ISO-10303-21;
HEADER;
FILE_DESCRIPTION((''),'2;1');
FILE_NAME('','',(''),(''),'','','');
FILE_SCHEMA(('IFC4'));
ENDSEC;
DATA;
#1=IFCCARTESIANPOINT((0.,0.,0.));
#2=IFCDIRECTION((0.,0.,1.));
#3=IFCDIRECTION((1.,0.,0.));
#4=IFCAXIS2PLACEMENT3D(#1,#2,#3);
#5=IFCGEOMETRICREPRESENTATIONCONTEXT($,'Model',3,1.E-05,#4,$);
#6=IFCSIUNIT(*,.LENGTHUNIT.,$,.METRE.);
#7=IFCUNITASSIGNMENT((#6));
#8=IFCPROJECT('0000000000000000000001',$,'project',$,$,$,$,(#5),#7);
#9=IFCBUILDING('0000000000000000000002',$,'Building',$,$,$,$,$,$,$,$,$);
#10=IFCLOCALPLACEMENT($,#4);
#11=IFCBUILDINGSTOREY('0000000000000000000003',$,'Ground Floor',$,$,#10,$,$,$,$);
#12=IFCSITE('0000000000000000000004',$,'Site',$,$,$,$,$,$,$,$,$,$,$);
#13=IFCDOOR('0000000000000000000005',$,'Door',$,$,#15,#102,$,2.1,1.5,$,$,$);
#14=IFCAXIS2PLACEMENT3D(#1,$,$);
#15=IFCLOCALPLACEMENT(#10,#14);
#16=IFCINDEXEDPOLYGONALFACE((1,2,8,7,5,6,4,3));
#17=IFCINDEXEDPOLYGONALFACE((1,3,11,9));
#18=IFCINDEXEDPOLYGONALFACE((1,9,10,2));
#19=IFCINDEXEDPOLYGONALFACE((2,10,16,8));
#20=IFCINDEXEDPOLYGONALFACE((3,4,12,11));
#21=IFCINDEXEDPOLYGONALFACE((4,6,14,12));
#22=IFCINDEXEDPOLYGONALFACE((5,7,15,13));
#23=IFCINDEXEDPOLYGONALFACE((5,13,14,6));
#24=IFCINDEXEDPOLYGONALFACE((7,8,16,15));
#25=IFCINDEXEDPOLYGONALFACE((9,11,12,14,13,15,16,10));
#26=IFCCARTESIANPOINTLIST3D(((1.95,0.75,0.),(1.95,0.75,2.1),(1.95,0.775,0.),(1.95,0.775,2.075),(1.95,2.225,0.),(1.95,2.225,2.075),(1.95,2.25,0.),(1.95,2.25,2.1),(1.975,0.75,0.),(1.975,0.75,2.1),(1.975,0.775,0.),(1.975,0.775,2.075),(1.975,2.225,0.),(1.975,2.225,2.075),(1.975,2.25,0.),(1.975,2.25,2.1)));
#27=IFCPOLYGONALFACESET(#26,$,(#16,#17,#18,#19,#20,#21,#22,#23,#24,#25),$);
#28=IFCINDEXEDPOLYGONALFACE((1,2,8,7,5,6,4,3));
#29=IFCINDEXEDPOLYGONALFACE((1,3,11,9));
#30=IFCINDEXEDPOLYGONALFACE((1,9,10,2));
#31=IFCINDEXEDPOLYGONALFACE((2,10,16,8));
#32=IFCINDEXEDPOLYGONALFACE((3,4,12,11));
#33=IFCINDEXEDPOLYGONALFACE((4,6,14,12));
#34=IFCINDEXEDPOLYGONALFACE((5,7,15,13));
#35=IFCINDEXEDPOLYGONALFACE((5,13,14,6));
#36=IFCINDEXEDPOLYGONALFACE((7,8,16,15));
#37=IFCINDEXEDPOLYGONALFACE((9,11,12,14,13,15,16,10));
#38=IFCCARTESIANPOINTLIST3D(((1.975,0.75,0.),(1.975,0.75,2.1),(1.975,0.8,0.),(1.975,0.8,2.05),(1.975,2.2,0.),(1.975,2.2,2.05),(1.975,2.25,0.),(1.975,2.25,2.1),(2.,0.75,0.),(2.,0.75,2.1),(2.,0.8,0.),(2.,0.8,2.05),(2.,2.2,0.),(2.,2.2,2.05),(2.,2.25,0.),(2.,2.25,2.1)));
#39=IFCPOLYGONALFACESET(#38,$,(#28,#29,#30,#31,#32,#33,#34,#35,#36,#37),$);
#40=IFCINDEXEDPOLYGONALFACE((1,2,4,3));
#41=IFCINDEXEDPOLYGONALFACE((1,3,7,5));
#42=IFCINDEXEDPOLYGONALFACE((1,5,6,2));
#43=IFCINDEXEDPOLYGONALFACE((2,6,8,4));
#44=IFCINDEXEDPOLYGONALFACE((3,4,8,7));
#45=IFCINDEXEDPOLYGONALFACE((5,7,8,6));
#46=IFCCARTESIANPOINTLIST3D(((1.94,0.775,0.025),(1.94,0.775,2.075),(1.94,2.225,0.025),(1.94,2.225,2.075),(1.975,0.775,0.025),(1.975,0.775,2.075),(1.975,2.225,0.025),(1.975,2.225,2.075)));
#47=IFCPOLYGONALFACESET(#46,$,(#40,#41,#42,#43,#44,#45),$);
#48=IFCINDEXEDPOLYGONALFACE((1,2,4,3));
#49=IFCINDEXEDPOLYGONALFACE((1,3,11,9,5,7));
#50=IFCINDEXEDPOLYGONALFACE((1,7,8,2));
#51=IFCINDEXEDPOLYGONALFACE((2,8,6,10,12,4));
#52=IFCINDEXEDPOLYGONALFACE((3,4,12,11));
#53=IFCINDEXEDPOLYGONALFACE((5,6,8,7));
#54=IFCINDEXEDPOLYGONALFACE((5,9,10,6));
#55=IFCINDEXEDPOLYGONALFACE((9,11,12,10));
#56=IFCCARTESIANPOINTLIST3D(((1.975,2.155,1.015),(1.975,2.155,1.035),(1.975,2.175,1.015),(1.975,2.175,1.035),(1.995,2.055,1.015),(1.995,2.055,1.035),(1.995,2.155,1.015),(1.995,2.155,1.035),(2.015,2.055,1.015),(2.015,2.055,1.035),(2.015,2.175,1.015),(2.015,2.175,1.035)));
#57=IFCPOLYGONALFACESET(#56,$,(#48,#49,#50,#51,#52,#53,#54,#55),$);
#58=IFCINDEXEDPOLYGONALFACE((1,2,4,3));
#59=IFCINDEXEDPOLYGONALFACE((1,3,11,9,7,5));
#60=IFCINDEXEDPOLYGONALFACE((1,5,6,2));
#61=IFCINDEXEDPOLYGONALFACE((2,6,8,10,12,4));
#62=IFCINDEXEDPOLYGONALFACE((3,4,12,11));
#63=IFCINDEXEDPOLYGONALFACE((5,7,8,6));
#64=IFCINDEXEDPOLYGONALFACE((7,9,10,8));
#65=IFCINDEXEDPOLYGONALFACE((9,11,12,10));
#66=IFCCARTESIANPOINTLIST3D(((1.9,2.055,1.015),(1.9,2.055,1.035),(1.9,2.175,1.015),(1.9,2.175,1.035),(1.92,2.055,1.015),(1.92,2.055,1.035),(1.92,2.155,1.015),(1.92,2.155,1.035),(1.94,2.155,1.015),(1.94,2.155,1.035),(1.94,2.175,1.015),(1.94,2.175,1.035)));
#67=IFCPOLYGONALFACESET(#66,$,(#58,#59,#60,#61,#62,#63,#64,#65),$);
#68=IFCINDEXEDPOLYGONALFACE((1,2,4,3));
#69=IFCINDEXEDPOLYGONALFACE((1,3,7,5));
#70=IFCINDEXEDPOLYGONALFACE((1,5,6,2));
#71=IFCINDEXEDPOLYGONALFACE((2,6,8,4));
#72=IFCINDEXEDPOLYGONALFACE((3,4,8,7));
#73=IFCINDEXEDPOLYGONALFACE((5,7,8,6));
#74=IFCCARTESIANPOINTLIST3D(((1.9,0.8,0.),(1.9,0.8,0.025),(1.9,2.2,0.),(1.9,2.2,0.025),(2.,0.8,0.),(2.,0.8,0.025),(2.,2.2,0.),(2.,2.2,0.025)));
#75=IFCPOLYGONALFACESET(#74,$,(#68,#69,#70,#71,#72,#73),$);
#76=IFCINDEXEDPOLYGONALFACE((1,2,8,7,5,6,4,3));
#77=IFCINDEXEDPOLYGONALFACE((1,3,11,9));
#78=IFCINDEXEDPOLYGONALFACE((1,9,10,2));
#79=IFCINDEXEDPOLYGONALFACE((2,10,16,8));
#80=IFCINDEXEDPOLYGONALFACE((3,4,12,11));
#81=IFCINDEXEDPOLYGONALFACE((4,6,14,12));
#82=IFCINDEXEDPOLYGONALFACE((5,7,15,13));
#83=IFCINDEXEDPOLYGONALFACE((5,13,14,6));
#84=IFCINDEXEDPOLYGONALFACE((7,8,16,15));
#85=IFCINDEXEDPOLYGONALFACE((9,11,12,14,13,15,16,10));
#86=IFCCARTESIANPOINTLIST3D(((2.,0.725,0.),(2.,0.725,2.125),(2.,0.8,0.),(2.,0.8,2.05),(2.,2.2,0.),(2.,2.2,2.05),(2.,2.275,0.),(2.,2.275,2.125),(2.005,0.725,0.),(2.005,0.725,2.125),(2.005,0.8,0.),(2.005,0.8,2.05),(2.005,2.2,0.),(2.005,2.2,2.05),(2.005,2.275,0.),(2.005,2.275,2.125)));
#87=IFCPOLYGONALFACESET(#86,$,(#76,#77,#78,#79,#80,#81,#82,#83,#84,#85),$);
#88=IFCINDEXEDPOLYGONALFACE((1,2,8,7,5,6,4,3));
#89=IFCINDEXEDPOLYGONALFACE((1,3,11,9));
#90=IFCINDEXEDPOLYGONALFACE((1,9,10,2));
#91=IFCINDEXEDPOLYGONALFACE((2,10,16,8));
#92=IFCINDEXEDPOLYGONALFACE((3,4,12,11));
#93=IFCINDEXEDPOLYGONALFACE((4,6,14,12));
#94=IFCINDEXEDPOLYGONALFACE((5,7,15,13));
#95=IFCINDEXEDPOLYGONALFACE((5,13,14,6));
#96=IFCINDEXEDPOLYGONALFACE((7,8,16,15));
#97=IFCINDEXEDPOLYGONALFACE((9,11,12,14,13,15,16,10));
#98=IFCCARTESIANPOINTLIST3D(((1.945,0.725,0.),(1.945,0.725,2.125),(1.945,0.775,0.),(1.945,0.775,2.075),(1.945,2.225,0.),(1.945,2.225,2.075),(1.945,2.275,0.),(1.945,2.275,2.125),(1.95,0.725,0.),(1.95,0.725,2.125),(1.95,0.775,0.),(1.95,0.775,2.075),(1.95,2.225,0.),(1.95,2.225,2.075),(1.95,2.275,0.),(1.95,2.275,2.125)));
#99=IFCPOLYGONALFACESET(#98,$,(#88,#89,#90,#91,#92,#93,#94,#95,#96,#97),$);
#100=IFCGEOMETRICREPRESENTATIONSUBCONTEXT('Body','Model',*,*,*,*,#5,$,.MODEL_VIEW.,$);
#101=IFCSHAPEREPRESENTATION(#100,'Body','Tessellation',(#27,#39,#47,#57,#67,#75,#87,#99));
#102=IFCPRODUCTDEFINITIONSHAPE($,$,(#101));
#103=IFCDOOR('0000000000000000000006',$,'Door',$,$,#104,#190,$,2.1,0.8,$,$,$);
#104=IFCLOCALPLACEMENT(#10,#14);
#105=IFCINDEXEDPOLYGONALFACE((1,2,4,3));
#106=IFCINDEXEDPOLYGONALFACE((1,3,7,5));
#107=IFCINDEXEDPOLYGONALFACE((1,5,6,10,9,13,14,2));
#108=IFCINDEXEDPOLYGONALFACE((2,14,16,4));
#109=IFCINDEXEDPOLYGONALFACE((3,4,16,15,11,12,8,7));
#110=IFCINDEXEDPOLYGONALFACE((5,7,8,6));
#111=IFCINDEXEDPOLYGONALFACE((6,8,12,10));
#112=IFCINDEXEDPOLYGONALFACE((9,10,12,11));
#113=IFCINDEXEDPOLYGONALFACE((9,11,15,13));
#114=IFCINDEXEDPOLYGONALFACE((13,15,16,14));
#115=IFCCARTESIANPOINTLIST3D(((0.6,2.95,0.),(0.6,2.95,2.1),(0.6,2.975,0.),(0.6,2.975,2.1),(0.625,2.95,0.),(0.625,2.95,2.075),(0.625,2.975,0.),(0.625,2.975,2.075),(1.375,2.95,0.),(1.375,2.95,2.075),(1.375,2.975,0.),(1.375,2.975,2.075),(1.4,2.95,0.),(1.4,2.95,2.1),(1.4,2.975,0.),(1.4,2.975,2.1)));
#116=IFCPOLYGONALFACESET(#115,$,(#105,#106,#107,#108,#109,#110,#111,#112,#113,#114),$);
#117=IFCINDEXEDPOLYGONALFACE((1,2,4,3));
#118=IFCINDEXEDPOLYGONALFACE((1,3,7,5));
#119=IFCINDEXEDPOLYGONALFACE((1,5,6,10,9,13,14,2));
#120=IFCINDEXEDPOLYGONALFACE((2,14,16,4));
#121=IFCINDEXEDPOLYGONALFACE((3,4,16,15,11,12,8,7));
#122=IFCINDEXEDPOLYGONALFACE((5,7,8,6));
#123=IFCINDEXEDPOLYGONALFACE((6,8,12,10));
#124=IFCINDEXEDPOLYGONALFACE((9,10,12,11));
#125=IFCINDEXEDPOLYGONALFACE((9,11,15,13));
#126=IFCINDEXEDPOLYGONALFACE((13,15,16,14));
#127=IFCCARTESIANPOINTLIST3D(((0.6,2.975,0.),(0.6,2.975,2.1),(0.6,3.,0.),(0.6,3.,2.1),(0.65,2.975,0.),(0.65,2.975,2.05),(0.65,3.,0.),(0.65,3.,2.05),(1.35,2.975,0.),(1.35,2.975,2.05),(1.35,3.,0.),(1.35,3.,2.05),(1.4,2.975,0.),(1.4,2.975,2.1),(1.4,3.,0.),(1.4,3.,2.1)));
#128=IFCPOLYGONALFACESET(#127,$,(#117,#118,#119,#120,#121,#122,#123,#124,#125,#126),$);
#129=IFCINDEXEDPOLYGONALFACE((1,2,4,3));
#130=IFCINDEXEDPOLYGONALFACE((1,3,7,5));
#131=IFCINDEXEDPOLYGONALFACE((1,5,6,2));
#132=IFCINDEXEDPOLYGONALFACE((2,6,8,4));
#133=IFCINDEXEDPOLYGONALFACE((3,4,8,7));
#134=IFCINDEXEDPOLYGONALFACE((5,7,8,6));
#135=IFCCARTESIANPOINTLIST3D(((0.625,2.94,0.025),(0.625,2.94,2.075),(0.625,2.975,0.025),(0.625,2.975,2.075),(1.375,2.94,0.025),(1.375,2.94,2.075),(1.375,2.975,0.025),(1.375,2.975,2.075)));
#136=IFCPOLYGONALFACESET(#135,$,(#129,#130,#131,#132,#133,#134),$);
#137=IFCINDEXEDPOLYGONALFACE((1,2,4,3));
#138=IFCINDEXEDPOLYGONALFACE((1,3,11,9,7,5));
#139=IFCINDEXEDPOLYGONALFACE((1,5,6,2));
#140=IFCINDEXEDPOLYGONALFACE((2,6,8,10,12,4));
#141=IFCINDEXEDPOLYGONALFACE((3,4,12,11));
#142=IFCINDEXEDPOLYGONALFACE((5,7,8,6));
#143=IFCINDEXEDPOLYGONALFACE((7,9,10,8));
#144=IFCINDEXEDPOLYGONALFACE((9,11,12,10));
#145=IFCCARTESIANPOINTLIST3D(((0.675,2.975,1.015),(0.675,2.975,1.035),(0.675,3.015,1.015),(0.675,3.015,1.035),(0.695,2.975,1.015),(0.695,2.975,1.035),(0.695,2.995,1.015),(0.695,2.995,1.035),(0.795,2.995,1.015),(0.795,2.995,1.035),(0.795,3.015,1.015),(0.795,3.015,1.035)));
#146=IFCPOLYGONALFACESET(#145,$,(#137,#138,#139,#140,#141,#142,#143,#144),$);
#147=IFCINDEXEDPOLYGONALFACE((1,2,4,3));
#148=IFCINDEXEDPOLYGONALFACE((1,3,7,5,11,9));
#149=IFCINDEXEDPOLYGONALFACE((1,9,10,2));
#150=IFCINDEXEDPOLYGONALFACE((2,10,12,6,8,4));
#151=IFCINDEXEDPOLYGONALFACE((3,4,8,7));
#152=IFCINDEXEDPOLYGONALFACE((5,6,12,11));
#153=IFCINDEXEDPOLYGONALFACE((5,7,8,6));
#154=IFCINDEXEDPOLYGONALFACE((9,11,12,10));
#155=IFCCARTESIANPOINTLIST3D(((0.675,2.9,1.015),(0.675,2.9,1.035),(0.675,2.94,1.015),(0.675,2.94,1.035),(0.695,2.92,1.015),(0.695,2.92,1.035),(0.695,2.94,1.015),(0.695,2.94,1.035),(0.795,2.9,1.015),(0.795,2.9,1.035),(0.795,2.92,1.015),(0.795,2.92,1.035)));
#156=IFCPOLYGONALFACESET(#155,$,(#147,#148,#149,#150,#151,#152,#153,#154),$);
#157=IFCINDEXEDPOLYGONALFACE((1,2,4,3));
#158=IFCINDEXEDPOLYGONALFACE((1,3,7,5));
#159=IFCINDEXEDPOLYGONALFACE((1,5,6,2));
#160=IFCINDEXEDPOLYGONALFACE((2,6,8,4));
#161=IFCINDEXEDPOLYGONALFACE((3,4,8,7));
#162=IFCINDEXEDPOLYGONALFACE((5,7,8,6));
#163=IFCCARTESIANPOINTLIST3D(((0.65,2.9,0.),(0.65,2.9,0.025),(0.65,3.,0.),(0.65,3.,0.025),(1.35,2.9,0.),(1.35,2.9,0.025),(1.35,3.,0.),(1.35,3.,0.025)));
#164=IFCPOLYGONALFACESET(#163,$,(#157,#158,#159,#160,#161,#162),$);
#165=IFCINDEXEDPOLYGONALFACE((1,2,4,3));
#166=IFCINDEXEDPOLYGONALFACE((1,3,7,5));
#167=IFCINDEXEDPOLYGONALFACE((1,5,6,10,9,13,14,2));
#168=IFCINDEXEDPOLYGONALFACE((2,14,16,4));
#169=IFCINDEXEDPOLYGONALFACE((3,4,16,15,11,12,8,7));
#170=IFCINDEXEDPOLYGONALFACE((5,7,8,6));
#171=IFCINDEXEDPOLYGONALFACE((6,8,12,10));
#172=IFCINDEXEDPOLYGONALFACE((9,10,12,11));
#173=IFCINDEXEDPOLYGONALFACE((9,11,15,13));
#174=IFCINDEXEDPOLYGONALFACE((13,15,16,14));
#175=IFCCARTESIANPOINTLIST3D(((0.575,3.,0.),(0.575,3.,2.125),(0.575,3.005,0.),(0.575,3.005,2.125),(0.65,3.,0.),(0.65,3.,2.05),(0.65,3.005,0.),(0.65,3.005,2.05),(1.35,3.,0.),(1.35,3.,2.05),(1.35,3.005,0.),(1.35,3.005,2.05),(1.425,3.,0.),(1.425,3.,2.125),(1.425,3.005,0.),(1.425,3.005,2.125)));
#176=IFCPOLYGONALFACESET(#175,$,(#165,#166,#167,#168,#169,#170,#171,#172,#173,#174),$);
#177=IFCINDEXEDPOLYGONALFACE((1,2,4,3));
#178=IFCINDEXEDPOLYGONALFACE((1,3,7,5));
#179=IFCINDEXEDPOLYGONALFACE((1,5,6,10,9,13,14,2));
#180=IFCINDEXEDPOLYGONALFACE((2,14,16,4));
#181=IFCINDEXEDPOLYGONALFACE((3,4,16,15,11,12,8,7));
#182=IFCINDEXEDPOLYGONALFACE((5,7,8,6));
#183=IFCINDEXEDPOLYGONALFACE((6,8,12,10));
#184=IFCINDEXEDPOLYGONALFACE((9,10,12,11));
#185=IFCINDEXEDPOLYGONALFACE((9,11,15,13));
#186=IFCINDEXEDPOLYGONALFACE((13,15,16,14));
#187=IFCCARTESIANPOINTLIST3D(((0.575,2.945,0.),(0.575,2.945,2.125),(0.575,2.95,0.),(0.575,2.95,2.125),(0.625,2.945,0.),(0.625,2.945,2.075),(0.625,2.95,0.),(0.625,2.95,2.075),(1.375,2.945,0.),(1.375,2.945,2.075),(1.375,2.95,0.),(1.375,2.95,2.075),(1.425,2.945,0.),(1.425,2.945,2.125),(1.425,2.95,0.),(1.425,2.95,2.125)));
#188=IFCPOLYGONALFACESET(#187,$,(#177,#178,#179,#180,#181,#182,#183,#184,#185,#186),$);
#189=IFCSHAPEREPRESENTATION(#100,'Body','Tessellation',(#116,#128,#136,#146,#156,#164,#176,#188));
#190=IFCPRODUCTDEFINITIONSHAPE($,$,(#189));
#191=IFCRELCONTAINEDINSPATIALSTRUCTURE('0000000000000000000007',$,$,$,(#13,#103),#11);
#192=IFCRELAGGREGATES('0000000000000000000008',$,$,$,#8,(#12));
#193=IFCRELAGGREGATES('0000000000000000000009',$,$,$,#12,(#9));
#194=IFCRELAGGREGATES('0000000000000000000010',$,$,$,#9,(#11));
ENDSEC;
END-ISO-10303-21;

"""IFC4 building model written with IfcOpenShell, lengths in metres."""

from ifc_helpers import new_model, si_unit, frame, origin_with_axes, place, context, subcontext, project, spatial, line, indexed_curve, outline, extrude, element, save


model = new_model("IFC4")

# Units and contexts
model_context = context("Model", 3, precision=1e-05, world=origin_with_axes())
body_context = subcontext(model_context, "Body", "Model", "MODEL_VIEW")
ifc_project = project(units=[si_unit("LENGTHUNIT", "METRE")], contexts=[model_context])

# Site, building, storey
site = spatial("IfcSite", under=ifc_project, Name="Site")
building = spatial("IfcBuilding", under=site, Name="Building")
storey_placement = place(None, origin_with_axes())
storey = spatial("IfcBuildingStorey", under=building, at=storey_placement, Name="Ground Floor")

# Doors
door_1_placement = place(storey_placement, frame((2.0, 0.75, 0.0), z_axis=(0.0, 0.0, 1.0), x_axis=(0.0, 1.0, 0.0)))
element("IfcDoor", 1, at=door_1_placement, inside=storey, Name="Door", OverallHeight=2.1, OverallWidth=1.5, context=body_context, shape_type="SweptSolid", body=[
    extrude(outline(indexed_curve([(0.0, 0.0), (0.0, 2.1), (1.5, 2.1), (1.5, 0.0), (1.475, 0.0), (1.475, 2.075), (0.025, 2.075), (0.025, 0.0)], segments=[line(1, 2, 3, 4, 5, 6, 7, 8, 1)])), frame((0.0, 0.025, 0.0), z_axis=(0.0, -1.0, 0.0), x_axis=(1.0, 0.0, 0.0)), (0.0, 0.0, -1.0), 0.025),
    extrude(outline(indexed_curve([(0.0, 0.0), (0.0, 2.1), (1.5, 2.1), (1.5, 0.0), (1.45, 0.0), (1.45, 2.05), (0.05, 2.05), (0.05, 0.0)], segments=[line(1, 2, 3, 4, 5, 6, 7, 8, 1)])), frame((0.0, 0.0, 0.0), z_axis=(0.0, -1.0, 0.0), x_axis=(1.0, 0.0, 0.0)), (0.0, 0.0, -1.0), 0.025),
    extrude(outline(indexed_curve([(0.0, 0.0), (1.45, 0.0), (1.45, 0.035), (0.0, 0.035)], segments=[line(1, 2, 3, 4, 1)])), frame((0.025, 0.025, 0.025), z_axis=(0.0, 0.0, 1.0), x_axis=(1.0, 0.0, 0.0)), (0.0, 0.0, 1.0), 2.05),
    extrude(outline(indexed_curve([(0.0, 0.0), (0.0, -0.04), (-0.12, -0.04), (-0.12, -0.02), (-0.02, -0.02), (-0.02, 0.0)], segments=[line(1, 2, 3, 4, 5, 6, 1)])), frame((1.425, 0.025, 1.015), z_axis=(0.0, 0.0, 1.0), x_axis=(1.0, 0.0, 0.0)), (0.0, 0.0, 1.0), 0.02),
    extrude(outline(indexed_curve([(0.0, 0.0), (0.0, 0.04), (-0.12, 0.04), (-0.12, 0.02), (-0.02, 0.02), (-0.02, 0.0)], segments=[line(1, 2, 3, 4, 5, 6, 1)])), frame((1.425, 0.06, 1.015), z_axis=(0.0, 0.0, 1.0), x_axis=(1.0, 0.0, 0.0)), (0.0, 0.0, 1.0), 0.02),
    extrude(outline(indexed_curve([(0.0, 0.0), (1.4, 0.0), (1.4, 0.1), (0.0, 0.1)], segments=[line(1, 2, 3, 4, 1)])), frame((0.05, 0.0, 0.0), z_axis=(0.0, 0.0, 1.0), x_axis=(1.0, 0.0, 0.0)), (0.0, 0.0, 1.0), 0.025),
    extrude(outline(indexed_curve([(0.0, 0.0), (0.0, 2.125), (1.55, 2.125), (1.55, 0.0), (1.475, 0.0), (1.475, 2.05), (0.075, 2.05), (0.075, 0.0)], segments=[line(1, 2, 3, 4, 5, 6, 7, 8, 1)])), frame((-0.025, -0.005, 0.0), z_axis=(0.0, -1.0, 0.0), x_axis=(1.0, 0.0, 0.0)), (0.0, 0.0, -1.0), 0.005),
    extrude(outline(indexed_curve([(0.0, 0.0), (0.0, 2.125), (1.55, 2.125), (1.55, 0.0), (1.5, 0.0), (1.5, 2.075), (0.05, 2.075), (0.05, 0.0)], segments=[line(1, 2, 3, 4, 5, 6, 7, 8, 1)])), frame((-0.025, 0.05, 0.0), z_axis=(0.0, -1.0, 0.0), x_axis=(1.0, 0.0, 0.0)), (0.0, 0.0, -1.0), 0.005),
])
door_2_placement = place(storey_placement, frame((1.4, 3.0, 0.0), z_axis=(0.0, 0.0, 1.0), x_axis=(-1.0, 0.0, 0.0)))
element("IfcDoor", 2, at=door_2_placement, inside=storey, Name="Door", OverallHeight=2.1, OverallWidth=0.8, context=body_context, shape_type="SweptSolid", body=[
    extrude(outline(indexed_curve([(0.0, 0.0), (0.0, 2.1), (0.8, 2.1), (0.8, 0.0), (0.775, 0.0), (0.775, 2.075), (0.025, 2.075), (0.025, 0.0)], segments=[line(1, 2, 3, 4, 5, 6, 7, 8, 1)])), frame((0.0, 0.025, 0.0), z_axis=(0.0, -1.0, 0.0), x_axis=(1.0, 0.0, 0.0)), (0.0, 0.0, -1.0), 0.025),
    extrude(outline(indexed_curve([(0.0, 0.0), (0.0, 2.1), (0.8, 2.1), (0.8, 0.0), (0.75, 0.0), (0.75, 2.05), (0.05, 2.05), (0.05, 0.0)], segments=[line(1, 2, 3, 4, 5, 6, 7, 8, 1)])), frame((0.0, 0.0, 0.0), z_axis=(0.0, -1.0, 0.0), x_axis=(1.0, 0.0, 0.0)), (0.0, 0.0, -1.0), 0.025),
    extrude(outline(indexed_curve([(0.0, 0.0), (0.75, 0.0), (0.75, 0.035), (0.0, 0.035)], segments=[line(1, 2, 3, 4, 1)])), frame((0.025, 0.025, 0.025), z_axis=(0.0, 0.0, 1.0), x_axis=(1.0, 0.0, 0.0)), (0.0, 0.0, 1.0), 2.05),
    extrude(outline(indexed_curve([(0.0, 0.0), (0.0, -0.04), (-0.12, -0.04), (-0.12, -0.02), (-0.02, -0.02), (-0.02, 0.0)], segments=[line(1, 2, 3, 4, 5, 6, 1)])), frame((0.725, 0.025, 1.015), z_axis=(0.0, 0.0, 1.0), x_axis=(1.0, 0.0, 0.0)), (0.0, 0.0, 1.0), 0.02),
    extrude(outline(indexed_curve([(0.0, 0.0), (0.0, 0.04), (-0.12, 0.04), (-0.12, 0.02), (-0.02, 0.02), (-0.02, 0.0)], segments=[line(1, 2, 3, 4, 5, 6, 1)])), frame((0.725, 0.06, 1.015), z_axis=(0.0, 0.0, 1.0), x_axis=(1.0, 0.0, 0.0)), (0.0, 0.0, 1.0), 0.02),
    extrude(outline(indexed_curve([(0.0, 0.0), (0.7, 0.0), (0.7, 0.1), (0.0, 0.1)], segments=[line(1, 2, 3, 4, 1)])), frame((0.05, 0.0, 0.0), z_axis=(0.0, 0.0, 1.0), x_axis=(1.0, 0.0, 0.0)), (0.0, 0.0, 1.0), 0.025),
    extrude(outline(indexed_curve([(0.0, 0.0), (0.0, 2.125), (0.85, 2.125), (0.85, 0.0), (0.775, 0.0), (0.775, 2.05), (0.075, 2.05), (0.075, 0.0)], segments=[line(1, 2, 3, 4, 5, 6, 7, 8, 1)])), frame((-0.025, -0.005, 0.0), z_axis=(0.0, -1.0, 0.0), x_axis=(1.0, 0.0, 0.0)), (0.0, 0.0, -1.0), 0.005),
    extrude(outline(indexed_curve([(0.0, 0.0), (0.0, 2.125), (0.85, 2.125), (0.85, 0.0), (0.8, 0.0), (0.8, 2.075), (0.05, 2.075), (0.05, 0.0)], segments=[line(1, 2, 3, 4, 5, 6, 7, 8, 1)])), frame((-0.025, 0.05, 0.0), z_axis=(0.0, -1.0, 0.0), x_axis=(1.0, 0.0, 0.0)), (0.0, 0.0, -1.0), 0.005),
])

save(model, "model.ifc")
